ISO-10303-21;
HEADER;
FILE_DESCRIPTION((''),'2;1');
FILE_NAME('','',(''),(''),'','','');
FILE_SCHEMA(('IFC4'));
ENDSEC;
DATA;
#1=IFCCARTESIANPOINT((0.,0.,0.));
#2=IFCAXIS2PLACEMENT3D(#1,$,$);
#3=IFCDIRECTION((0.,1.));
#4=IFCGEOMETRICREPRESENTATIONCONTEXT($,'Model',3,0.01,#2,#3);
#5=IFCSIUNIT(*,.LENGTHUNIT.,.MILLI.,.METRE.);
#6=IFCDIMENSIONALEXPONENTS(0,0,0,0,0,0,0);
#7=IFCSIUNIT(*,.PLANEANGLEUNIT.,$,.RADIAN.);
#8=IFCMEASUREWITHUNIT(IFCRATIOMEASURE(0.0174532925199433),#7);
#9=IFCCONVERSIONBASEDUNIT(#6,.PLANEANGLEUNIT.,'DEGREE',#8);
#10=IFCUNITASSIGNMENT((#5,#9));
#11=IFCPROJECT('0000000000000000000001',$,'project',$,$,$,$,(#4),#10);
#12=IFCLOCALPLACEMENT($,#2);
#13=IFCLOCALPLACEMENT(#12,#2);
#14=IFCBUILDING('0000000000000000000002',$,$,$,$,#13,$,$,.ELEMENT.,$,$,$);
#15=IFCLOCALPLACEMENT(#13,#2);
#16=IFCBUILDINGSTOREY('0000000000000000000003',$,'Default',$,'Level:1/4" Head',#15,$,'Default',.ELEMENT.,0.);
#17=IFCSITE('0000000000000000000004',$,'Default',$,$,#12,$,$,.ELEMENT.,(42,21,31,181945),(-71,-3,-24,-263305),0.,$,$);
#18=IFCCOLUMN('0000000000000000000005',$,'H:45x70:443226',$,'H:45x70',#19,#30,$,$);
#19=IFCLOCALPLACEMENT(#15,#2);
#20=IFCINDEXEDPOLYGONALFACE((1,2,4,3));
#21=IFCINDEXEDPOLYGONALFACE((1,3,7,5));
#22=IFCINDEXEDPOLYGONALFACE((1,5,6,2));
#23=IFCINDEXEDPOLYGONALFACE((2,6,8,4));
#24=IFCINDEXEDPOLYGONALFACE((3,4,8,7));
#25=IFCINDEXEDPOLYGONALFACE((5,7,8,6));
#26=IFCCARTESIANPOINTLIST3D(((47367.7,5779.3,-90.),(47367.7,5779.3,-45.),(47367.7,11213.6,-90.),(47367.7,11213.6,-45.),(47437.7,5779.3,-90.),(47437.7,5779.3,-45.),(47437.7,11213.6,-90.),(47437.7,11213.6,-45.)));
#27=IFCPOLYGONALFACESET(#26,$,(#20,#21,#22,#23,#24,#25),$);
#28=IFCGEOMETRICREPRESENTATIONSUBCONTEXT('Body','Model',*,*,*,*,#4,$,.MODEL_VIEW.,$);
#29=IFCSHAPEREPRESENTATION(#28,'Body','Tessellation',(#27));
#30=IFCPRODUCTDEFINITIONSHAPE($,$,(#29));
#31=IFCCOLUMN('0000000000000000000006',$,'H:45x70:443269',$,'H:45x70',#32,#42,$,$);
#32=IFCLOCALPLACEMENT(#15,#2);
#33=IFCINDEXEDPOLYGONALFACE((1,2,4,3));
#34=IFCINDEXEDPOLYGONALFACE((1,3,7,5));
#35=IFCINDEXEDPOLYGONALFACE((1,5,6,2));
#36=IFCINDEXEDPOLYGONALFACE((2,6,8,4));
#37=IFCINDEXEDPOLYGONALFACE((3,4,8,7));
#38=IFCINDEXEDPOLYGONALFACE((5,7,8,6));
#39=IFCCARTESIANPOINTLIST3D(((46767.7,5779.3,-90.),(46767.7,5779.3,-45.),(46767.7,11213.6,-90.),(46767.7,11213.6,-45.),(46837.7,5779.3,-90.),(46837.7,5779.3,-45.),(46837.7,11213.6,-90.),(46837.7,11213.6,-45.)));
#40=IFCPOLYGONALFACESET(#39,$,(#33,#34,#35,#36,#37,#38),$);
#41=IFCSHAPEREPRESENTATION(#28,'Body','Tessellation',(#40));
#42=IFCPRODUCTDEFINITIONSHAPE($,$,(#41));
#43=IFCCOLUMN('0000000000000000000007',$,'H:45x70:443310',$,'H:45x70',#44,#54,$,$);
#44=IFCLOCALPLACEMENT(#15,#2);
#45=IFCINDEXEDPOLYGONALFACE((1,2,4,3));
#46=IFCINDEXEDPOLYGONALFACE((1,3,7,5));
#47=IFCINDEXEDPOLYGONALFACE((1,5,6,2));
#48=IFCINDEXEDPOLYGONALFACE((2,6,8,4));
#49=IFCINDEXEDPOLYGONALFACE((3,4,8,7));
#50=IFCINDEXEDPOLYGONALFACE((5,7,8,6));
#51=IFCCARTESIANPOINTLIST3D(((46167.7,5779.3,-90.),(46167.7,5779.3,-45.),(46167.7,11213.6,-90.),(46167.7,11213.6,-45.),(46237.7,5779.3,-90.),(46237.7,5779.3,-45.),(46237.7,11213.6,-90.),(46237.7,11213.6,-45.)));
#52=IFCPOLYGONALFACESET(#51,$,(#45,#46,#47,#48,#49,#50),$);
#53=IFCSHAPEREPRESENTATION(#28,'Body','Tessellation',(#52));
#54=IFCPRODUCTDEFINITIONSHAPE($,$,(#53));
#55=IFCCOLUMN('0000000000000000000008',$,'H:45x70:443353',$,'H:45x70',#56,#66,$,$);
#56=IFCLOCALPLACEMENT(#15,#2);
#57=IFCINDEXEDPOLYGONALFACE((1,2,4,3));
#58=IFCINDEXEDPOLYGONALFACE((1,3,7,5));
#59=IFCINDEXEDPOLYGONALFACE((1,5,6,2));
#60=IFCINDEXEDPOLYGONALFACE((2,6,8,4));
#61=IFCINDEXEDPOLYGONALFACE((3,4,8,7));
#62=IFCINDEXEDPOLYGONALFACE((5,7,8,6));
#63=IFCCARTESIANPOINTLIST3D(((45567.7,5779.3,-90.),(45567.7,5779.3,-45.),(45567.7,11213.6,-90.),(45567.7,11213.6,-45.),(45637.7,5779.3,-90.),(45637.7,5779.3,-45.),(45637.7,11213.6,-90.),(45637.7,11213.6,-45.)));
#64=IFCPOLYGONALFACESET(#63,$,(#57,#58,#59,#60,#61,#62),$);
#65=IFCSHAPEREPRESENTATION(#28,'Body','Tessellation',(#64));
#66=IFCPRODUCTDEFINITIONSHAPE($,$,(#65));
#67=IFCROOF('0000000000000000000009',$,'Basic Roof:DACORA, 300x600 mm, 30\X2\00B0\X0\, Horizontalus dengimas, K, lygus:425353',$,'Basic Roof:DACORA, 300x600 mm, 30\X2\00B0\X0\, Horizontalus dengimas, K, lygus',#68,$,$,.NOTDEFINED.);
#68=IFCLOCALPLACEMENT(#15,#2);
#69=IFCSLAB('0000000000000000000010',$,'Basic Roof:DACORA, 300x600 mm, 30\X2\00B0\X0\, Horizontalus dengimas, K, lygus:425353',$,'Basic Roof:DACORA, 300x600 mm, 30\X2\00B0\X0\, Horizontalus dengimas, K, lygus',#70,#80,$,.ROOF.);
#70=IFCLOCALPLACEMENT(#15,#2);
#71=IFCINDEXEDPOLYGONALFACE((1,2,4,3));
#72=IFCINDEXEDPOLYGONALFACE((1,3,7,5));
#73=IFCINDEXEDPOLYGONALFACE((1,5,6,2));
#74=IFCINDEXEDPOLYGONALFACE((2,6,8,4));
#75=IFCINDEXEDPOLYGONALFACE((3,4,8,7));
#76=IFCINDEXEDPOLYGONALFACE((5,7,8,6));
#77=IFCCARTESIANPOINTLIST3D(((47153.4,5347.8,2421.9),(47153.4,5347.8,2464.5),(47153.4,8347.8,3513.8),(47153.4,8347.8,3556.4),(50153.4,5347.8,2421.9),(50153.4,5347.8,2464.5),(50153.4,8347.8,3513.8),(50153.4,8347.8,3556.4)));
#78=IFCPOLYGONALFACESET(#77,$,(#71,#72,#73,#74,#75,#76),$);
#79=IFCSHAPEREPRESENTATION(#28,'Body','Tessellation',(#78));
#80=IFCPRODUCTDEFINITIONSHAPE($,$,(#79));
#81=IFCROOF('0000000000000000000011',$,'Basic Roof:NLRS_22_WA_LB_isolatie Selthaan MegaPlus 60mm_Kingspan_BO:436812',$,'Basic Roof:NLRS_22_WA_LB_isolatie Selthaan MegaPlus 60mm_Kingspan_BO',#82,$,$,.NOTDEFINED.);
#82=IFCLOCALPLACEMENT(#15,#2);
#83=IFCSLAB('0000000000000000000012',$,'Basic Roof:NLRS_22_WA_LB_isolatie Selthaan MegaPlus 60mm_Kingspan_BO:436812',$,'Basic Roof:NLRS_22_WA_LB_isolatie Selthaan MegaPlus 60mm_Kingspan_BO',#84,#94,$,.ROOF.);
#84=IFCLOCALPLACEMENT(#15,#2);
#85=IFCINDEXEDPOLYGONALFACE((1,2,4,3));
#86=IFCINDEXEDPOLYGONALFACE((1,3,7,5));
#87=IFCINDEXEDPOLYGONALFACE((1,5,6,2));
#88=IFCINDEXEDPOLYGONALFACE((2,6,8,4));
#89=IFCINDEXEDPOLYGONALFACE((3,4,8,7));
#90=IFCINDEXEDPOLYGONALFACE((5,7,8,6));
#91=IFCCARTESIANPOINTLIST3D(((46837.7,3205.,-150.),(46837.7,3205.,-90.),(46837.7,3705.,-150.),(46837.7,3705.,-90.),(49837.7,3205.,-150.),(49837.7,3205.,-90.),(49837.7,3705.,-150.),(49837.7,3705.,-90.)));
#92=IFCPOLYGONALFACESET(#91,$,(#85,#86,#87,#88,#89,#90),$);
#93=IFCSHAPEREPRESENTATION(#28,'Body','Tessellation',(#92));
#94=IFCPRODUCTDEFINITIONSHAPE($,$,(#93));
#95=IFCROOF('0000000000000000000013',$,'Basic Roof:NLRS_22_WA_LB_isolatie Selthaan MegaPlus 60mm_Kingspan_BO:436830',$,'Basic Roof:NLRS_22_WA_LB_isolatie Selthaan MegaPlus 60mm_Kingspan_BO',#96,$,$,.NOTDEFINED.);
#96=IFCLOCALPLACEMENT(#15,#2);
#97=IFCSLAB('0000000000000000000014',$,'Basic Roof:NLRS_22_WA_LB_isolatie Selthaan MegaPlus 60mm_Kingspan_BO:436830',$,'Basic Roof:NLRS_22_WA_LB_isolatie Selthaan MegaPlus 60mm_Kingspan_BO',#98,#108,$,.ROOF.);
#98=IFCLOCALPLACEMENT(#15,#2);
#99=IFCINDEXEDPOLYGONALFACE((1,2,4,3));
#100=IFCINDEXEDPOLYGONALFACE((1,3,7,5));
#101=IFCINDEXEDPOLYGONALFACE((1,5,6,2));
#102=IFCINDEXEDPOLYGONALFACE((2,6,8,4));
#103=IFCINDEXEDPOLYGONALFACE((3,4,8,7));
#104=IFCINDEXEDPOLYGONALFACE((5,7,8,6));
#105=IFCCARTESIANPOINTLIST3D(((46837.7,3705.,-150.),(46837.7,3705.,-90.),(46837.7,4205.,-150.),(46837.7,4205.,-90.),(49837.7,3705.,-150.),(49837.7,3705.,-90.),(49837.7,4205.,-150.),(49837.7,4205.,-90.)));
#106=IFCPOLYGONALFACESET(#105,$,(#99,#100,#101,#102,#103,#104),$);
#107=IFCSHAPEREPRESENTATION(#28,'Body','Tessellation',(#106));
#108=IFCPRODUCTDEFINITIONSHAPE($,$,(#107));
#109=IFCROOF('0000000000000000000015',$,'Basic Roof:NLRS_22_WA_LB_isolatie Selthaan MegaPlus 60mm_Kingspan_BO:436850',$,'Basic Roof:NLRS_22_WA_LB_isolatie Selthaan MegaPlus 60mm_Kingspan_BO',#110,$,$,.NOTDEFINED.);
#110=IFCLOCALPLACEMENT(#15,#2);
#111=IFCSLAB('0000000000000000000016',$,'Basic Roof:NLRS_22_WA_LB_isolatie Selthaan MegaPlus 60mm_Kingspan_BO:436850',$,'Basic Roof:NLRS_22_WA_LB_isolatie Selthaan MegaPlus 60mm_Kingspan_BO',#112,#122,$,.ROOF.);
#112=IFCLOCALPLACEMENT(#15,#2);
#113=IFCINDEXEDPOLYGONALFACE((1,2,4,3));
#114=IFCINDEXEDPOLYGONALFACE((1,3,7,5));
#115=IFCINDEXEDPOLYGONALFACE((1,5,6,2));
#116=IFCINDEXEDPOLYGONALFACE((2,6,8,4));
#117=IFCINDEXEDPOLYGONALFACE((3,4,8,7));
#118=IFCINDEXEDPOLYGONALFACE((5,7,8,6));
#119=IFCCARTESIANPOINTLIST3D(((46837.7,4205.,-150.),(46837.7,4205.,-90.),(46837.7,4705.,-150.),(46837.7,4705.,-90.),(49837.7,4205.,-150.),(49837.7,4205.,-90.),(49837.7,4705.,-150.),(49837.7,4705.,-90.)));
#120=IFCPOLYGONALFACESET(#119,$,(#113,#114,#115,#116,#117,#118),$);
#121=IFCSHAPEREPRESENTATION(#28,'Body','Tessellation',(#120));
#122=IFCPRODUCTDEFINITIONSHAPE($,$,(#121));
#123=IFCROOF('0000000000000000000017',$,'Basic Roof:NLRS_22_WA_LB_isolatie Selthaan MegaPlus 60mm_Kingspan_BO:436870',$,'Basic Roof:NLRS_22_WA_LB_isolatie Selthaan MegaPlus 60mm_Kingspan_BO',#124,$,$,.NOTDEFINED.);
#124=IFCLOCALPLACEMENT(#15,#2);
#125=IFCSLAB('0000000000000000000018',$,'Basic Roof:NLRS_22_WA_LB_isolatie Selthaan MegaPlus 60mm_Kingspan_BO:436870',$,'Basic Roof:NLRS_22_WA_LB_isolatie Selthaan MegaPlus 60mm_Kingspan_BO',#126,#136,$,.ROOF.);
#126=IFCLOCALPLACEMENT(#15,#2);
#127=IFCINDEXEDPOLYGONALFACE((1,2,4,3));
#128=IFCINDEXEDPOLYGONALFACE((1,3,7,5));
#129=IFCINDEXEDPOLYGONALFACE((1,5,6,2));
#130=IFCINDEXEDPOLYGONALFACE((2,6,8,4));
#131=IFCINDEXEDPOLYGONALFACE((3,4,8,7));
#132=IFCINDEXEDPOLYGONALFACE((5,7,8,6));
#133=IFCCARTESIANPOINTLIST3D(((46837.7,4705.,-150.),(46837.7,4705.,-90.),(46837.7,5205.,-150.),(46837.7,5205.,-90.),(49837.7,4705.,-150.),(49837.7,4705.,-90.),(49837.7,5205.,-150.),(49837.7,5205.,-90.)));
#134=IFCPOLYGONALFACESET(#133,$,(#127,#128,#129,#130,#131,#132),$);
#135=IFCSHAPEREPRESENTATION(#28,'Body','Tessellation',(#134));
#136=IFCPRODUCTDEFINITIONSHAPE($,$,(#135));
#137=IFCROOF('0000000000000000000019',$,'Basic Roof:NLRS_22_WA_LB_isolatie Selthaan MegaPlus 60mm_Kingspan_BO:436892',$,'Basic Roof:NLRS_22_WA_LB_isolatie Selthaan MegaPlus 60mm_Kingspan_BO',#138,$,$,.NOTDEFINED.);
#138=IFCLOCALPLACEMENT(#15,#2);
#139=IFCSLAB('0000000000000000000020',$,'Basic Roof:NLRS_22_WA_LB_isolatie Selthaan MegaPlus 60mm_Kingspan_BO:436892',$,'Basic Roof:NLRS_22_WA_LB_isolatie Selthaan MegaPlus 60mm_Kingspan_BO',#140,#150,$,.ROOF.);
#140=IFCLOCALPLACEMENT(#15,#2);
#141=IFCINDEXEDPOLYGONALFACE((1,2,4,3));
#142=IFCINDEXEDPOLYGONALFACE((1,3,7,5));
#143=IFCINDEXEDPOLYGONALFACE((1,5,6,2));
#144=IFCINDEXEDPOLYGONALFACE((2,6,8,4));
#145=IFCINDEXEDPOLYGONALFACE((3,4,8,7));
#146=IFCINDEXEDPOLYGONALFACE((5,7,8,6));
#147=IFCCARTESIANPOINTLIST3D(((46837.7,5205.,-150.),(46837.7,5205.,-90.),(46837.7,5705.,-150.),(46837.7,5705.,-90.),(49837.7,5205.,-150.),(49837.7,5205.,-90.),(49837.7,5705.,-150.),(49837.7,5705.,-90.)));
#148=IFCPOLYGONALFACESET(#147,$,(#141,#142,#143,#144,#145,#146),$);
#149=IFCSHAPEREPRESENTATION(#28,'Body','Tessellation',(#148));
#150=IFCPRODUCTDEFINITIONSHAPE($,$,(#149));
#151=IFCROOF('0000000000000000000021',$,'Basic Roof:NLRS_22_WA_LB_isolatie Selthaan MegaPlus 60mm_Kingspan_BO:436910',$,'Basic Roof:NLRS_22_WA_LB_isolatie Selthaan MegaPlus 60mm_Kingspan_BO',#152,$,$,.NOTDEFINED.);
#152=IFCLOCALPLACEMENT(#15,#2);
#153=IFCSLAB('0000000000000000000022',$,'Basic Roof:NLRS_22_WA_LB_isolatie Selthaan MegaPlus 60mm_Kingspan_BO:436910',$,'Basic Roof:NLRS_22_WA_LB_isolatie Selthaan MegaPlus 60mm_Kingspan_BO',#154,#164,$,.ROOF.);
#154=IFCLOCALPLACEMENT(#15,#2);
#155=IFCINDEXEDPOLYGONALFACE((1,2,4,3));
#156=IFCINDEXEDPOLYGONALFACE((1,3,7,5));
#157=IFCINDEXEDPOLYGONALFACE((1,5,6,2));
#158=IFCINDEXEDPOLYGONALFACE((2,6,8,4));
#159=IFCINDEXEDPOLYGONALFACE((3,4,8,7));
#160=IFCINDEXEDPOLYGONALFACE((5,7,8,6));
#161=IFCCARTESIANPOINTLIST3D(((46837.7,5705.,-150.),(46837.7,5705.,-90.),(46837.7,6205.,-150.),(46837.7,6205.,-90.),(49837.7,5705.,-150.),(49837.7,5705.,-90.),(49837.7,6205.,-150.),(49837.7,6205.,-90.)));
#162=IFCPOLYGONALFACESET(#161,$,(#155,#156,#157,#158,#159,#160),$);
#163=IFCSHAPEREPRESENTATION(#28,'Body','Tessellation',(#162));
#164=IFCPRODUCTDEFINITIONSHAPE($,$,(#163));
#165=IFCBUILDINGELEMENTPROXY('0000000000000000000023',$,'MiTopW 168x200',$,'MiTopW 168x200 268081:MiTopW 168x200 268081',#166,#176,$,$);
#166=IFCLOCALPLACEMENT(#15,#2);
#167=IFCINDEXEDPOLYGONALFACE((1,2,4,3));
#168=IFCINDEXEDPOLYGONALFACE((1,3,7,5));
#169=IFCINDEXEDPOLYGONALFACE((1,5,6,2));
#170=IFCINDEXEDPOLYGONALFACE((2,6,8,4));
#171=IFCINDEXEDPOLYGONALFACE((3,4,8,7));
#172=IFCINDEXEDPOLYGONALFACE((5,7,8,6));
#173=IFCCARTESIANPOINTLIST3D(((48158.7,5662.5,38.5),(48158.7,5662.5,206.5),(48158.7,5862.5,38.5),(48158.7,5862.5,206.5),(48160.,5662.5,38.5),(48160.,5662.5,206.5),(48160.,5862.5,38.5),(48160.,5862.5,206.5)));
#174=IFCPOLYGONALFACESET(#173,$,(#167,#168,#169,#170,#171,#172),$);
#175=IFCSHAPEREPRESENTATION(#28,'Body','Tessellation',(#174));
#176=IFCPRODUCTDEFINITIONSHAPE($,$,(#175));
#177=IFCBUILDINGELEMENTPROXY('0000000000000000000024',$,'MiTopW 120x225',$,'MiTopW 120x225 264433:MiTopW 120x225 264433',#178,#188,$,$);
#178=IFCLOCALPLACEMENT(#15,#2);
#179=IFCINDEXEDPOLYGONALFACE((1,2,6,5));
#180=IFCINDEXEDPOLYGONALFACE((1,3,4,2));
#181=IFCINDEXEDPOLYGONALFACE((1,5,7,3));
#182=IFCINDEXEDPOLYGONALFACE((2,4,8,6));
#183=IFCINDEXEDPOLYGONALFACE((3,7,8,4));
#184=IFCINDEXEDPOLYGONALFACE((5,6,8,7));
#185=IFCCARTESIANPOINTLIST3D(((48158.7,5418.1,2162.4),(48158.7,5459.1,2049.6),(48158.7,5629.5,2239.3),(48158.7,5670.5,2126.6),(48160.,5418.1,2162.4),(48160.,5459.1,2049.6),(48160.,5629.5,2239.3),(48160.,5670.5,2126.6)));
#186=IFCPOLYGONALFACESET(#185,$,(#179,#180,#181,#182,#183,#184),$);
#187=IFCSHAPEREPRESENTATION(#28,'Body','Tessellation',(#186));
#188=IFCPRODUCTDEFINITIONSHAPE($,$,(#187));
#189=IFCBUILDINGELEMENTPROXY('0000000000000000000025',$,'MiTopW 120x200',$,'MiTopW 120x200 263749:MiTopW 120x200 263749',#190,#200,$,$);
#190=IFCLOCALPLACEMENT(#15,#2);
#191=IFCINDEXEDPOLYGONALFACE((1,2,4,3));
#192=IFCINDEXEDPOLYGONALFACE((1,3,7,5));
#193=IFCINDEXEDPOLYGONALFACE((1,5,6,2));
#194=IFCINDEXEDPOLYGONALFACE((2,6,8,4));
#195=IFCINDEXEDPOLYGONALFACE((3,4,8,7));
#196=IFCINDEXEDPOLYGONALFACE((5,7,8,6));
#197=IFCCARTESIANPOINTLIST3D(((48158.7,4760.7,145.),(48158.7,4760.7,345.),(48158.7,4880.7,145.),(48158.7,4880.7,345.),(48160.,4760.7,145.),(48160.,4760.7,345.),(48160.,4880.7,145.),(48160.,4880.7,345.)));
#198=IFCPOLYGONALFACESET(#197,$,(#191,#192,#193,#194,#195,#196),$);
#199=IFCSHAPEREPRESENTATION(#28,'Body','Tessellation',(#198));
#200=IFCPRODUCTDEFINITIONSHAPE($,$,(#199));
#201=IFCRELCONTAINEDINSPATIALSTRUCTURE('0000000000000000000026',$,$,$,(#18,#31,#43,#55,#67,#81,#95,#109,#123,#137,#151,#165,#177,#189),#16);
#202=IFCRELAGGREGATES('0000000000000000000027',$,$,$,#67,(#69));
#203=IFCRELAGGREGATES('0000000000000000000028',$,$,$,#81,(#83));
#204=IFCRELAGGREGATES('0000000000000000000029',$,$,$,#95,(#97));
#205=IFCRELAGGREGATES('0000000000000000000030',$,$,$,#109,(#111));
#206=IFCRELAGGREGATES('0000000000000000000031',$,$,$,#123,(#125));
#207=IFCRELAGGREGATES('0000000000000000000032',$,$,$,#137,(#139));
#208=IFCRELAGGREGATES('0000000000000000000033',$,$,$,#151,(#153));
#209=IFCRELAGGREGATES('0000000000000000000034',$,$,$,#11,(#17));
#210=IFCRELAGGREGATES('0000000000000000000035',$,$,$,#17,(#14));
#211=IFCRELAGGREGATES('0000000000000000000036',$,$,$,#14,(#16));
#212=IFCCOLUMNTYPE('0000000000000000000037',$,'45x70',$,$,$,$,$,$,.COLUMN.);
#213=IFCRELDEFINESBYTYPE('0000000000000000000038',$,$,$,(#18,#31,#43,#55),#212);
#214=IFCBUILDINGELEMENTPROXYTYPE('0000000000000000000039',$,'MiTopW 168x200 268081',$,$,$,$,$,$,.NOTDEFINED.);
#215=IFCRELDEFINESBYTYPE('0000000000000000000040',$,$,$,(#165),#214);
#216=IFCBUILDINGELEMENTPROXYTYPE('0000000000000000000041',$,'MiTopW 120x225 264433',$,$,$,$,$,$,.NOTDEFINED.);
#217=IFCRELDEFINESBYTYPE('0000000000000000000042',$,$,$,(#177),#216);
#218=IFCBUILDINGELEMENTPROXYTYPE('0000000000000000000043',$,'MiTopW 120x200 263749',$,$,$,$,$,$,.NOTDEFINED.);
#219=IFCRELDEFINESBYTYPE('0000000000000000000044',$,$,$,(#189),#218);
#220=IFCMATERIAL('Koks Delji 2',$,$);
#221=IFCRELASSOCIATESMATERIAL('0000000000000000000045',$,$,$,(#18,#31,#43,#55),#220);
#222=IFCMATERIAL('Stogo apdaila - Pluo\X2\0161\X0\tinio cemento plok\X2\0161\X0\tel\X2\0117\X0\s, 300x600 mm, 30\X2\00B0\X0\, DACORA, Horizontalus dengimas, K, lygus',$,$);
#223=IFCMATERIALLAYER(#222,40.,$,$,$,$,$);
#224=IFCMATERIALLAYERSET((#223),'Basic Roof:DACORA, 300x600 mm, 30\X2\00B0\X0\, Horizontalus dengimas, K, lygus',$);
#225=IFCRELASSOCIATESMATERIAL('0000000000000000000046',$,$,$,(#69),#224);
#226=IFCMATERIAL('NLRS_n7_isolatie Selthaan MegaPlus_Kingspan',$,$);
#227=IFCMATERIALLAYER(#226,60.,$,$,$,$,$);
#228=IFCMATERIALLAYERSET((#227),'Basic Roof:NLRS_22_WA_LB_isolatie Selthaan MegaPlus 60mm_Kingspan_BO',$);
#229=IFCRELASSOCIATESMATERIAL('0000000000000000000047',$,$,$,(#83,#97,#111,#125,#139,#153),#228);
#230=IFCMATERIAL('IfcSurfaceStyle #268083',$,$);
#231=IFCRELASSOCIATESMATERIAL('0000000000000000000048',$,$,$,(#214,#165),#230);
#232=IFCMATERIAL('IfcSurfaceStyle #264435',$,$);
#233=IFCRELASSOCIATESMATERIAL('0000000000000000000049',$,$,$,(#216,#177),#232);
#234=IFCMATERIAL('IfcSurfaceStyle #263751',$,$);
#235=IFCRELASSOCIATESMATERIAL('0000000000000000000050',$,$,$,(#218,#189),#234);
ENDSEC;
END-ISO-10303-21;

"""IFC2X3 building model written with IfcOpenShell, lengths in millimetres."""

from ifc_helpers import new_model, entity, si_unit, converted_unit, direction, frame, frame_2d, origin, origin_2d_with_axis, place, context, subcontext, project, spatial, polyline, rectangle, outline, extrude, source, transform, mapped, material, layer, layer_set, type_object, type_shapes, element, aggregate, save


model = new_model("IFC2X3")

# Units and contexts
model_context = context("Model", 3, precision=0.01, world=origin(), true_north=direction((0.0, 1.0)))
body_context = subcontext(model_context, "Body", "Model", "MODEL_VIEW")
ifc_project = project(units=[si_unit("LENGTHUNIT", "METRE", prefix="MILLI"), converted_unit("PLANEANGLEUNIT", "DEGREE", entity("IfcRatioMeasure", 0.0174532925199433), si_unit("PLANEANGLEUNIT", "RADIAN"), dimensions=[0, 0, 0, 0, 0, 0, 0])], contexts=[model_context])

# Site, building, storey
site_placement = place(None, origin())
site = spatial("IfcSite", under=ifc_project, at=site_placement, Name="Default", CompositionType="ELEMENT", RefLatitude=(42, 21, 31, 181945), RefLongitude=(-71, -3, -24, -263305), RefElevation=0.0)
building_placement = place(site_placement, origin())
building = spatial("IfcBuilding", under=site, at=building_placement, CompositionType="ELEMENT")
storey_placement = place(building_placement, origin())
storey = spatial("IfcBuildingStorey", under=building, at=storey_placement, Name="Default", ObjectType="Level:1/4\" Head", LongName="Default", CompositionType="ELEMENT", Elevation=0.0)

# Columns
ifc_material_1 = material(Name="Koks Delji 2")
column_type = type_object("IfcColumnType", Name="45x70", PredefinedType="COLUMN")
shared_shape_1 = source(origin(), body_context, "Body", "SweptSolid", [
    extrude(rectangle(XDim=70.0, YDim=5434.3, at=frame_2d((0.0, 0.0), x_axis=(1.0, 0.0))), frame((2717.1, 237.8, 0.0), z_axis=(0.0, 0.0, 1.0), x_axis=(0.0, -1.0, 0.0)), (0.0, 0.0, 1.0), 45.0),
])
type_shapes(column_type, [shared_shape_1])
for number, where, z_axis, x_axis, name in (
    (1, (47640.6, 5779.3, -90.0), (0.0, 0.0, 1.0), (0.0, 1.0, 0.0), "H:45x70:443226"),
    (2, (47040.6, 5779.3, -90.0), (0.0, 0.0, 1.0), (0.0, 1.0, 0.0), "H:45x70:443269"),
    (3, (46440.6, 5779.3, -90.0), (0.0, 0.0, 1.0), (0.0, 1.0, 0.0), "H:45x70:443310"),
    (4, (45840.6, 5779.3, -90.0), (0.0, 0.0, 1.0), (0.0, 1.0, 0.0), "H:45x70:443353"),
):
    element("IfcColumn", number, at=place(storey_placement, frame(where, z_axis=z_axis, x_axis=x_axis)), inside=storey, type_object=column_type, material=ifc_material_1, Name=name, ObjectType="H:45x70", context=body_context, shape_type="MappedRepresentation", body=[
        mapped(shared_shape_1, transform((0.0, 0.0, 0.0), scale=1.0)),
    ])

# Roofs, slabs
roof_1_placement = place(building_placement, frame((47153.4, 5347.8, 2421.9)))
roof_1 = element("IfcRoof", 5, at=roof_1_placement, inside=storey, Name="Basic Roof:DACORA, 300x600 mm, 30°, Horizontalus dengimas, K, lygus:425353", ObjectType="Basic Roof:DACORA, 300x600 mm, 30°, Horizontalus dengimas, K, lygus", ShapeType="NOTDEFINED")
ifc_material_2 = material(Name="Stogo apdaila - Pluoštinio cemento plokštelės, 300x600 mm, 30°, DACORA, Horizontalus dengimas, K, lygus")
ifc_layer_1 = layer(ifc_material_2, 40.0)
ifc_layer_set_1 = layer_set([ifc_layer_1], Name="Basic Roof:DACORA, 300x600 mm, 30°, Horizontalus dengimas, K, lygus")
slab_1_placement = place(roof_1_placement, origin())
slab_1 = element("IfcSlab", 6, at=slab_1_placement, material=ifc_layer_set_1, Name="Basic Roof:DACORA, 300x600 mm, 30°, Horizontalus dengimas, K, lygus:425353", ObjectType="Basic Roof:DACORA, 300x600 mm, 30°, Horizontalus dengimas, K, lygus", PredefinedType="ROOF", context=body_context, shape_type="SweptSolid", body=[
    extrude(rectangle(XDim=3192.5, YDim=3000.0, at=frame_2d((0.0, 0.0), x_axis=(0.0, -1.0))), frame((1500.0, 1500.0, 546.0), z_axis=(0.0, -0.34202, 0.939693), x_axis=(1.0, 0.0, 0.0)), (0.0, 0.34202, 0.939693), 42.6),
])
aggregate(roof_1, [slab_1])
roof_2_placement = place(storey_placement, frame((46837.7, 3205.0, -150.0)))
roof_2 = element("IfcRoof", 7, at=roof_2_placement, inside=storey, Name="Basic Roof:NLRS_22_WA_LB_isolatie Selthaan MegaPlus 60mm_Kingspan_BO:436812", ObjectType="Basic Roof:NLRS_22_WA_LB_isolatie Selthaan MegaPlus 60mm_Kingspan_BO", ShapeType="NOTDEFINED")
ifc_material_3 = material(Name="NLRS_n7_isolatie Selthaan MegaPlus_Kingspan")
ifc_layer_2 = layer(ifc_material_3, 60.0)
ifc_layer_set_2 = layer_set([ifc_layer_2], Name="Basic Roof:NLRS_22_WA_LB_isolatie Selthaan MegaPlus 60mm_Kingspan_BO")
slab_2_placement = place(roof_2_placement, origin())
slab_2 = element("IfcSlab", 8, at=slab_2_placement, material=ifc_layer_set_2, Name="Basic Roof:NLRS_22_WA_LB_isolatie Selthaan MegaPlus 60mm_Kingspan_BO:436812", ObjectType="Basic Roof:NLRS_22_WA_LB_isolatie Selthaan MegaPlus 60mm_Kingspan_BO", PredefinedType="ROOF", context=body_context, shape_type="SweptSolid", body=[
    extrude(rectangle(XDim=3000.0, YDim=500.0, at=origin_2d_with_axis()), frame((1500.0, 250.0, 0.0)), (0.0, 0.0, 1.0), 60.0),
])
aggregate(roof_2, [slab_2])
roof_3_placement = place(storey_placement, frame((46837.7, 3705.0, -150.0)))
roof_3 = element("IfcRoof", 9, at=roof_3_placement, inside=storey, Name="Basic Roof:NLRS_22_WA_LB_isolatie Selthaan MegaPlus 60mm_Kingspan_BO:436830", ObjectType="Basic Roof:NLRS_22_WA_LB_isolatie Selthaan MegaPlus 60mm_Kingspan_BO", ShapeType="NOTDEFINED")
slab_3_placement = place(roof_3_placement, origin())
slab_3 = element("IfcSlab", 10, at=slab_3_placement, material=ifc_layer_set_2, Name="Basic Roof:NLRS_22_WA_LB_isolatie Selthaan MegaPlus 60mm_Kingspan_BO:436830", ObjectType="Basic Roof:NLRS_22_WA_LB_isolatie Selthaan MegaPlus 60mm_Kingspan_BO", PredefinedType="ROOF", context=body_context, shape_type="SweptSolid", body=[
    extrude(rectangle(XDim=3000.0, YDim=500.0, at=origin_2d_with_axis()), frame((1500.0, 250.0, 0.0)), (0.0, 0.0, 1.0), 60.0),
])
aggregate(roof_3, [slab_3])
roof_4_placement = place(storey_placement, frame((46837.7, 4205.0, -150.0)))
roof_4 = element("IfcRoof", 11, at=roof_4_placement, inside=storey, Name="Basic Roof:NLRS_22_WA_LB_isolatie Selthaan MegaPlus 60mm_Kingspan_BO:436850", ObjectType="Basic Roof:NLRS_22_WA_LB_isolatie Selthaan MegaPlus 60mm_Kingspan_BO", ShapeType="NOTDEFINED")
slab_4_placement = place(roof_4_placement, origin())
slab_4 = element("IfcSlab", 12, at=slab_4_placement, material=ifc_layer_set_2, Name="Basic Roof:NLRS_22_WA_LB_isolatie Selthaan MegaPlus 60mm_Kingspan_BO:436850", ObjectType="Basic Roof:NLRS_22_WA_LB_isolatie Selthaan MegaPlus 60mm_Kingspan_BO", PredefinedType="ROOF", context=body_context, shape_type="SweptSolid", body=[
    extrude(rectangle(XDim=3000.0, YDim=500.0, at=origin_2d_with_axis()), frame((1500.0, 250.0, 0.0)), (0.0, 0.0, 1.0), 60.0),
])
aggregate(roof_4, [slab_4])
roof_5_placement = place(storey_placement, frame((46837.7, 4705.0, -150.0)))
roof_5 = element("IfcRoof", 13, at=roof_5_placement, inside=storey, Name="Basic Roof:NLRS_22_WA_LB_isolatie Selthaan MegaPlus 60mm_Kingspan_BO:436870", ObjectType="Basic Roof:NLRS_22_WA_LB_isolatie Selthaan MegaPlus 60mm_Kingspan_BO", ShapeType="NOTDEFINED")
slab_5_placement = place(roof_5_placement, origin())
slab_5 = element("IfcSlab", 14, at=slab_5_placement, material=ifc_layer_set_2, Name="Basic Roof:NLRS_22_WA_LB_isolatie Selthaan MegaPlus 60mm_Kingspan_BO:436870", ObjectType="Basic Roof:NLRS_22_WA_LB_isolatie Selthaan MegaPlus 60mm_Kingspan_BO", PredefinedType="ROOF", context=body_context, shape_type="SweptSolid", body=[
    extrude(rectangle(XDim=3000.0, YDim=500.0, at=origin_2d_with_axis()), frame((1500.0, 250.0, 0.0)), (0.0, 0.0, 1.0), 60.0),
])
aggregate(roof_5, [slab_5])
roof_6_placement = place(storey_placement, frame((46837.7, 5205.0, -150.0)))
roof_6 = element("IfcRoof", 15, at=roof_6_placement, inside=storey, Name="Basic Roof:NLRS_22_WA_LB_isolatie Selthaan MegaPlus 60mm_Kingspan_BO:436892", ObjectType="Basic Roof:NLRS_22_WA_LB_isolatie Selthaan MegaPlus 60mm_Kingspan_BO", ShapeType="NOTDEFINED")
slab_6_placement = place(roof_6_placement, origin())
slab_6 = element("IfcSlab", 16, at=slab_6_placement, material=ifc_layer_set_2, Name="Basic Roof:NLRS_22_WA_LB_isolatie Selthaan MegaPlus 60mm_Kingspan_BO:436892", ObjectType="Basic Roof:NLRS_22_WA_LB_isolatie Selthaan MegaPlus 60mm_Kingspan_BO", PredefinedType="ROOF", context=body_context, shape_type="SweptSolid", body=[
    extrude(rectangle(XDim=3000.0, YDim=500.0, at=origin_2d_with_axis()), frame((1500.0, 250.0, 0.0)), (0.0, 0.0, 1.0), 60.0),
])
aggregate(roof_6, [slab_6])
roof_7_placement = place(storey_placement, frame((46837.7, 5705.0, -150.0)))
roof_7 = element("IfcRoof", 17, at=roof_7_placement, inside=storey, Name="Basic Roof:NLRS_22_WA_LB_isolatie Selthaan MegaPlus 60mm_Kingspan_BO:436910", ObjectType="Basic Roof:NLRS_22_WA_LB_isolatie Selthaan MegaPlus 60mm_Kingspan_BO", ShapeType="NOTDEFINED")
slab_7_placement = place(roof_7_placement, origin())
slab_7 = element("IfcSlab", 18, at=slab_7_placement, material=ifc_layer_set_2, Name="Basic Roof:NLRS_22_WA_LB_isolatie Selthaan MegaPlus 60mm_Kingspan_BO:436910", ObjectType="Basic Roof:NLRS_22_WA_LB_isolatie Selthaan MegaPlus 60mm_Kingspan_BO", PredefinedType="ROOF", context=body_context, shape_type="SweptSolid", body=[
    extrude(rectangle(XDim=3000.0, YDim=500.0, at=origin_2d_with_axis()), frame((1500.0, 250.0, 0.0)), (0.0, 0.0, 1.0), 60.0),
])
aggregate(roof_7, [slab_7])

# Building element proxies
ifc_material_4 = material(Name="IfcSurfaceStyle #268083")
building_element_proxy_type_1 = type_object("IfcBuildingElementProxyType", Name="MiTopW 168x200 268081", PredefinedType="NOTDEFINED", material=ifc_material_4)
shared_shape_2 = source(origin(), body_context, "Body", "SweptSolid", [
    extrude(rectangle(XDim=200.0, YDim=168.0, at=origin_2d_with_axis()), frame((100.0, 84.0, 0.0), z_axis=(0.0, 0.0, 1.0), x_axis=(-1.0, 0.0, 0.0)), (0.0, 0.0, 1.0), 1.3),
])
type_shapes(building_element_proxy_type_1, [shared_shape_2])
proxy_1_placement = place(building_placement, frame((48160.0, 5662.5, 206.5), z_axis=(-1.0, 0.0, 0.0), x_axis=(0.0, 1.0, 0.0)))
element("IfcBuildingElementProxy", 19, at=proxy_1_placement, inside=storey, type_object=building_element_proxy_type_1, material=ifc_material_4, Name="MiTopW 168x200", ObjectType="MiTopW 168x200 268081:MiTopW 168x200 268081", context=body_context, shape_type="MappedRepresentation", body=[
    mapped(shared_shape_2, transform((0.0, 0.0, 0.0), scale=1.0)),
])
ifc_material_5 = material(Name="IfcSurfaceStyle #264435")
building_element_proxy_type_2 = type_object("IfcBuildingElementProxyType", Name="MiTopW 120x225 264433", PredefinedType="NOTDEFINED", material=ifc_material_5)
shared_shape_3 = source(origin(), body_context, "Body", "SweptSolid", [
    extrude(outline(polyline([(-112.5, -60.0), (112.5, -60.0), (112.5, 60.0), (-112.5, 60.0), (-112.5, -60.0)])), frame((112.5, 60.0, 0.0), z_axis=(0.0, 0.0, 1.0), x_axis=(-1.0, 0.0, 0.0)), (0.0, 0.0, 1.0), 1.3),
])
type_shapes(building_element_proxy_type_2, [shared_shape_3])
proxy_2_placement = place(building_placement, frame((48160.0, 5418.1, 2162.4), z_axis=(-1.0, 0.0, 0.0), x_axis=(0.0, 0.939693, 0.34202)))
element("IfcBuildingElementProxy", 20, at=proxy_2_placement, inside=storey, type_object=building_element_proxy_type_2, material=ifc_material_5, Name="MiTopW 120x225", ObjectType="MiTopW 120x225 264433:MiTopW 120x225 264433", context=body_context, shape_type="MappedRepresentation", body=[
    mapped(shared_shape_3, transform((0.0, 0.0, 0.0), scale=1.0)),
])
ifc_material_6 = material(Name="IfcSurfaceStyle #263751")
building_element_proxy_type_3 = type_object("IfcBuildingElementProxyType", Name="MiTopW 120x200 263749", PredefinedType="NOTDEFINED", material=ifc_material_6)
shared_shape_4 = source(origin(), body_context, "Body", "SweptSolid", [
    extrude(rectangle(XDim=200.0, YDim=120.0, at=origin_2d_with_axis()), frame((100.0, 60.0, 0.0), z_axis=(0.0, 0.0, 1.0), x_axis=(-1.0, 0.0, 0.0)), (0.0, 0.0, 1.0), 1.3),
])
type_shapes(building_element_proxy_type_3, [shared_shape_4])
proxy_3_placement = place(building_placement, frame((48160.0, 4760.7, 145.0), z_axis=(-1.0, 0.0, 0.0), x_axis=(0.0, 0.0, 1.0)))
element("IfcBuildingElementProxy", 21, at=proxy_3_placement, inside=storey, type_object=building_element_proxy_type_3, material=ifc_material_6, Name="MiTopW 120x200", ObjectType="MiTopW 120x200 263749:MiTopW 120x200 263749", context=body_context, shape_type="MappedRepresentation", body=[
    mapped(shared_shape_4, transform((0.0, 0.0, 0.0), scale=1.0)),
])

save(model, "model.ifc")
